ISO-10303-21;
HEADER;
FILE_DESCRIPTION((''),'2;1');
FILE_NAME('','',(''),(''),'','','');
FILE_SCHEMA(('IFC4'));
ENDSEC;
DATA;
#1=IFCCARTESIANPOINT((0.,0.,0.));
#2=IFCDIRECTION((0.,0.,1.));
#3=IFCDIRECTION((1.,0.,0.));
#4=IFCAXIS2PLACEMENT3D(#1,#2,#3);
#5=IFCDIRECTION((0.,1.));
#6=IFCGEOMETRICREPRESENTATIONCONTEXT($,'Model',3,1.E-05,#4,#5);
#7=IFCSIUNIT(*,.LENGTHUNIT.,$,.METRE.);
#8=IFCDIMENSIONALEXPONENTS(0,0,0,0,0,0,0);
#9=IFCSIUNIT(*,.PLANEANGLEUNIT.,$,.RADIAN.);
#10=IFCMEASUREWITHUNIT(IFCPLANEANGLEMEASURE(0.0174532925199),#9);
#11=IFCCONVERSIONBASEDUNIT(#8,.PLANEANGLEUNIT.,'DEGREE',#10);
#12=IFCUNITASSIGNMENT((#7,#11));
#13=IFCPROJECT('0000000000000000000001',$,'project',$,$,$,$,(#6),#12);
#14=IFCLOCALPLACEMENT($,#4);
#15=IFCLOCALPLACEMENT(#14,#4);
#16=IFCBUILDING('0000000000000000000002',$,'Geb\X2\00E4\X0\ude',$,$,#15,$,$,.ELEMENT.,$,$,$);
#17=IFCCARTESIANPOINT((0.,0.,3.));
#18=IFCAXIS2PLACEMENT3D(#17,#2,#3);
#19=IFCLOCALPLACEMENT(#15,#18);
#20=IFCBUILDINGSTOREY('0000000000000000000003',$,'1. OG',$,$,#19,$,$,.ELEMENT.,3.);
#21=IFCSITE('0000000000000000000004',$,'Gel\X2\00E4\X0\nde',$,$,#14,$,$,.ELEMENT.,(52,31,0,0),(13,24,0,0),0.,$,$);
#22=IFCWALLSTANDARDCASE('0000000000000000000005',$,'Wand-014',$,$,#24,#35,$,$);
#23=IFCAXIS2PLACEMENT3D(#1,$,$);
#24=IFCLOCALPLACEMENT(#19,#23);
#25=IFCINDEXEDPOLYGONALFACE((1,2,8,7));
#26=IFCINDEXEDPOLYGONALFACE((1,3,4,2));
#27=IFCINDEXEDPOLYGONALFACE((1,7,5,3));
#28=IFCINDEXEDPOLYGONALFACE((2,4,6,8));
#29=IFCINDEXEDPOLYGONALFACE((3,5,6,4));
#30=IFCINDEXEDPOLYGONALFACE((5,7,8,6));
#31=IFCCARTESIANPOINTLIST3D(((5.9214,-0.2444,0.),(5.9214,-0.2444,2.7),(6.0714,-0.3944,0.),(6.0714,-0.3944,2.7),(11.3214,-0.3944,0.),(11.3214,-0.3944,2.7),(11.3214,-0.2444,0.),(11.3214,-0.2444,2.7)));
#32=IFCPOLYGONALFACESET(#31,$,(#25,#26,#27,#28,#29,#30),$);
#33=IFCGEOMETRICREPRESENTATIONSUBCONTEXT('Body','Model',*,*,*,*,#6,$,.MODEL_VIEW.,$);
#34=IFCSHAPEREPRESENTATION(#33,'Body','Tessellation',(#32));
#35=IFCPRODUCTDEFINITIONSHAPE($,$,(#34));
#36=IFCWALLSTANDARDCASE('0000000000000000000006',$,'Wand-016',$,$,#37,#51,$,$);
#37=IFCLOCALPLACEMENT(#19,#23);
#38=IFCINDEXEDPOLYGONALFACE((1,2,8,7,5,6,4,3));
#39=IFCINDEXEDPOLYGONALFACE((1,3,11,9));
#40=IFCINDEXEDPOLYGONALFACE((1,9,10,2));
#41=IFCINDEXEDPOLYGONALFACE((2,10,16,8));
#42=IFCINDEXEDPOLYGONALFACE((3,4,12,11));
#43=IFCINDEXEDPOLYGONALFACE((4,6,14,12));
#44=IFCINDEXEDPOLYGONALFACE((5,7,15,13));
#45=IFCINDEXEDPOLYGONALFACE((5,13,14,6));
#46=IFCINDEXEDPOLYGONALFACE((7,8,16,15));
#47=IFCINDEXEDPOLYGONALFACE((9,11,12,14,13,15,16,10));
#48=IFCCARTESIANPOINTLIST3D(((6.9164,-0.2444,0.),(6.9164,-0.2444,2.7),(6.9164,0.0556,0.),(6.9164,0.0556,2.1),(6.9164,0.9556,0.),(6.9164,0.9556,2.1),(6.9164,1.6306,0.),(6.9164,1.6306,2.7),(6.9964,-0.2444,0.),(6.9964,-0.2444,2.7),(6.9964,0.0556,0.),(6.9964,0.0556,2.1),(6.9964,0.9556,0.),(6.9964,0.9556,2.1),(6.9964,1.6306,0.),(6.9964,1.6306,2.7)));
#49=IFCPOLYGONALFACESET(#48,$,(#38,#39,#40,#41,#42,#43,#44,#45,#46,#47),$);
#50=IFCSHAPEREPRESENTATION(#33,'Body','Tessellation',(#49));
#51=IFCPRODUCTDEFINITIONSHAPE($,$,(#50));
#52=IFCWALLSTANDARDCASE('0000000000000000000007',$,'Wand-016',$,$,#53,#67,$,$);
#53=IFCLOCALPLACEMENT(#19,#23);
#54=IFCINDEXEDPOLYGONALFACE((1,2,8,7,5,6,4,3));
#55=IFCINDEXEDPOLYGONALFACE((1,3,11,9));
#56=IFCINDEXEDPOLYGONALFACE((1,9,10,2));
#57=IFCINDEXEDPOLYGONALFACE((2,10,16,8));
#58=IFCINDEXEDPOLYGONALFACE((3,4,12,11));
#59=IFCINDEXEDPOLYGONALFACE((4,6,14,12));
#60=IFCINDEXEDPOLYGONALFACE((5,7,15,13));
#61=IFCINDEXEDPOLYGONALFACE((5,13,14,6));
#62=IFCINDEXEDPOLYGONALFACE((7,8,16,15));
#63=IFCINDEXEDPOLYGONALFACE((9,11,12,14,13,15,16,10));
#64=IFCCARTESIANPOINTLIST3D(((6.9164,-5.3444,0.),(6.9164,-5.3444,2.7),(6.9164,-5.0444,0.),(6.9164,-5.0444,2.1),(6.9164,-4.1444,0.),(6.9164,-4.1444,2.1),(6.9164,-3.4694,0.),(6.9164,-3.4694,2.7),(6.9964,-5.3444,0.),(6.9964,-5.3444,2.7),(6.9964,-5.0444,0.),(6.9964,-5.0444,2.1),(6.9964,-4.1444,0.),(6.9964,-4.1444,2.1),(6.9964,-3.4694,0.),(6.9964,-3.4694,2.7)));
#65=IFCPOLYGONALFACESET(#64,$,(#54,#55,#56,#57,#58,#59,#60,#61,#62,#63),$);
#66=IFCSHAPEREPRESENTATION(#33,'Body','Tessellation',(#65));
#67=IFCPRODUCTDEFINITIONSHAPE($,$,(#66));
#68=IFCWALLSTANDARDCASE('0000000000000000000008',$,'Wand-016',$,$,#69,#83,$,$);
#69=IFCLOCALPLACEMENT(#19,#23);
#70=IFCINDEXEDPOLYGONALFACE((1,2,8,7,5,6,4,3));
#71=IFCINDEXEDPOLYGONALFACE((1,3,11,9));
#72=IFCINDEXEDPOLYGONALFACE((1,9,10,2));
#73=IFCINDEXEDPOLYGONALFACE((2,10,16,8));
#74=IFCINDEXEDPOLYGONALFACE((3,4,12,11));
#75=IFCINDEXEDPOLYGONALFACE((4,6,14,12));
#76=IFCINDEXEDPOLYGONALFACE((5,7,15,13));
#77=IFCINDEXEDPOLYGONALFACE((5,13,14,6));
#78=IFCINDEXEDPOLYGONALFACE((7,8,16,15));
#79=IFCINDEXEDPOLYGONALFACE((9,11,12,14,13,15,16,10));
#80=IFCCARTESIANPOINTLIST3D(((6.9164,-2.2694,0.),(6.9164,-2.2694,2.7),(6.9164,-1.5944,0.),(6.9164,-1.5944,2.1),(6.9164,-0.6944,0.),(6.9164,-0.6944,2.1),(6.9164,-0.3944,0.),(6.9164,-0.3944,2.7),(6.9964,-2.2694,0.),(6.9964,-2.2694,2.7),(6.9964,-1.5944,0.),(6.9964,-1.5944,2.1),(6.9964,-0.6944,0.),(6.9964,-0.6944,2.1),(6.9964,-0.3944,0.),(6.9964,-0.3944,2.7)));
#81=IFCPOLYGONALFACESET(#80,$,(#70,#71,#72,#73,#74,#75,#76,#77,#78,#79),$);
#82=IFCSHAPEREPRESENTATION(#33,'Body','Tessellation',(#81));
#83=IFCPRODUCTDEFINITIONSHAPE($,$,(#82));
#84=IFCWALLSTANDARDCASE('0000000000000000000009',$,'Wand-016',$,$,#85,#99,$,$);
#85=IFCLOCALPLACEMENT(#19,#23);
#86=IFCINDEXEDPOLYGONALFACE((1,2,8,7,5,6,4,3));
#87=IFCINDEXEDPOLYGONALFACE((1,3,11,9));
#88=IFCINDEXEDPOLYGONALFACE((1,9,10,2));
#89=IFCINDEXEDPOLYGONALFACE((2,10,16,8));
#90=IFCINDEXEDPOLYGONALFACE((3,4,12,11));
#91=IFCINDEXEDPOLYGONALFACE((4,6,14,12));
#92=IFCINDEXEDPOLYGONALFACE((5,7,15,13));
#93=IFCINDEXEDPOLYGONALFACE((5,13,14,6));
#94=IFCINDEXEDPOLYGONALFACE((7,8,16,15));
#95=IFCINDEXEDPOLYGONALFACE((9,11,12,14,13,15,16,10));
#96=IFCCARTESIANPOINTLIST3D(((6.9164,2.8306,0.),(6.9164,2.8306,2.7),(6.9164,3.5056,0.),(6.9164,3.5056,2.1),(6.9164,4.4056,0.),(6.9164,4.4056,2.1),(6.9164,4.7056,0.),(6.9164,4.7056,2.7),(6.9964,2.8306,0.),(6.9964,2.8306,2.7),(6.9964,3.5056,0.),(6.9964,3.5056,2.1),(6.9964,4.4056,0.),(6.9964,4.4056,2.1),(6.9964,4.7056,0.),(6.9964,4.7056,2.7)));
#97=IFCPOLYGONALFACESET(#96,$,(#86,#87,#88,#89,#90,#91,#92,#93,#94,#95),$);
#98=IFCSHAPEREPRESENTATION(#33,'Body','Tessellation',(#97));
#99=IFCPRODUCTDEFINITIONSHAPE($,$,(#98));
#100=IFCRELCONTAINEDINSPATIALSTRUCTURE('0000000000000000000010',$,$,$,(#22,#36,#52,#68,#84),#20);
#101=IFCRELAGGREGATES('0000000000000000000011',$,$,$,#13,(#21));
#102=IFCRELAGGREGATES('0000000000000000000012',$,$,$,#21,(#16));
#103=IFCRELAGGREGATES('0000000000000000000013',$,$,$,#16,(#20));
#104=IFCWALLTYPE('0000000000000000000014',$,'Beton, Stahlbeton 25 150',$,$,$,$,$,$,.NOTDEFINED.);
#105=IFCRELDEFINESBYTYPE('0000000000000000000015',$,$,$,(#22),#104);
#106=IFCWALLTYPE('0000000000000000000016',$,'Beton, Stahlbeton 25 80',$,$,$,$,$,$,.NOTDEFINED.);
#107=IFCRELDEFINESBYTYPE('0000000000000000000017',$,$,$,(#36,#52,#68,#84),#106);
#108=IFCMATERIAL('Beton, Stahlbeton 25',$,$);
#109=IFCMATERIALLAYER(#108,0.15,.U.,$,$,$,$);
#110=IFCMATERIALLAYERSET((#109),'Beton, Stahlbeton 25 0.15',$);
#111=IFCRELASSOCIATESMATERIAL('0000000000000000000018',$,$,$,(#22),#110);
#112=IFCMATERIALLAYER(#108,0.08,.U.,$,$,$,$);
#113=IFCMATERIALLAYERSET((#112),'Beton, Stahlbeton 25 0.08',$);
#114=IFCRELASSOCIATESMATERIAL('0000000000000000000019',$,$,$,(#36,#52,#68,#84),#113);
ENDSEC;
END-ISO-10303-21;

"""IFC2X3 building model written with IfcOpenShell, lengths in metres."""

from ifc_helpers import new_model, entity, si_unit, converted_unit, direction, frame, origin_with_axes, origin_2d_with_axis, place, context, subcontext, project, spatial, polyline, rectangle, outline, extrude, material, layer, layer_set, layer_usage, type_object, element, save


model = new_model("IFC2X3")

# Units and contexts
model_context = context("Model", 3, precision=1e-05, world=origin_with_axes(), true_north=direction((0.0, 1.0)))
body_context = subcontext(model_context, "Body", "Model", "MODEL_VIEW")
ifc_project = project(units=[si_unit("LENGTHUNIT", "METRE"), converted_unit("PLANEANGLEUNIT", "DEGREE", entity("IfcPlaneAngleMeasure", 0.0174532925199), si_unit("PLANEANGLEUNIT", "RADIAN"), dimensions=[0, 0, 0, 0, 0, 0, 0])], contexts=[model_context])

# Site, building, storey
site_placement = place(None, origin_with_axes())
site = spatial("IfcSite", under=ifc_project, at=site_placement, Name="Gelände", CompositionType="ELEMENT", RefLatitude=(52, 31, 0, 0), RefLongitude=(13, 24, 0, 0), RefElevation=0.0)
building_placement = place(site_placement, origin_with_axes())
building = spatial("IfcBuilding", under=site, at=building_placement, Name="Gebäude", CompositionType="ELEMENT")
storey_placement = place(building_placement, frame((0.0, 0.0, 3.0), z_axis=(0.0, 0.0, 1.0), x_axis=(1.0, 0.0, 0.0)))
storey = spatial("IfcBuildingStorey", under=building, at=storey_placement, Name="1. OG", CompositionType="ELEMENT", Elevation=3.0)

# Shared definitions
ifc_material = material(Name="Beton, Stahlbeton 25")
ifc_layer_1 = layer(ifc_material, 0.15, ventilated="UNKNOWN")
ifc_layer_set_1 = layer_set([ifc_layer_1], Name="Beton, Stahlbeton 25 0.15")
wall_type_1 = type_object("IfcWallType", Name="Beton, Stahlbeton 25 150", PredefinedType="NOTDEFINED")

# Wall
ifc_layer_usage_1 = layer_usage(ifc_layer_set_1, "AXIS2", "NEGATIVE", 0.075)
wall_1_placement = place(storey_placement, frame((11.3214, -0.3194, 0.0), z_axis=(0.0, 0.0, 1.0), x_axis=(-1.0, 0.0, 0.0)))
element("IfcWallStandardCase", 1, at=wall_1_placement, inside=storey, type_object=wall_type_1, material=ifc_layer_usage_1, Name="Wand-014", context=body_context, shape_type="SweptSolid", body=[
    extrude(outline(polyline([(0.0, -0.075), (5.4, -0.075), (5.25, 0.075), (0.0, 0.075), (0.0, -0.075)])), origin_with_axes(), (0.0, 0.0, 1.0), 2.7),
])

# Walls, openings
ifc_layer_2 = layer(ifc_material, 0.08, ventilated="UNKNOWN")
ifc_layer_set_2 = layer_set([ifc_layer_2], Name="Beton, Stahlbeton 25 0.08")
ifc_layer_usage_2 = layer_usage(ifc_layer_set_2, "AXIS2", "POSITIVE", 0.0)
wall_type_2 = type_object("IfcWallType", Name="Beton, Stahlbeton 25 80", PredefinedType="NOTDEFINED")
wall_2_placement = place(storey_placement, frame((6.9164, 1.6306, 0.0), z_axis=(0.0, 0.0, 1.0), x_axis=(0.0, -1.0, 0.0)))
wall_2 = element("IfcWallStandardCase", 2, at=wall_2_placement, inside=storey, type_object=wall_type_2, material=ifc_layer_usage_2, Name="Wand-016", context=body_context, shape_type="SweptSolid", body=[
    extrude(outline(polyline([(0.0, 0.0), (1.875, 0.0), (1.875, 0.08), (0.0, 0.08), (0.0, 0.0)])), origin_with_axes(), (0.0, 0.0, 1.0), 2.7),
])
opening_1_placement = place(wall_2_placement, frame((1.125, 0.0, 0.0), z_axis=(0.0, 0.0, 1.0), x_axis=(1.0, 0.0, 0.0)))
element("IfcOpeningElement", 3, at=opening_1_placement, cuts=wall_2, context=body_context, shape_type="SweptSolid", body=[
    extrude(rectangle(XDim=0.9, YDim=2.1, at=origin_2d_with_axis()), frame((0.0, -0.08, 1.05), z_axis=(0.0, 1.0, 0.0), x_axis=(1.0, 0.0, 0.0)), (0.0, 0.0, 1.0), 0.08),
    extrude(rectangle(XDim=0.9, YDim=2.1, at=origin_2d_with_axis()), frame((0.0, 0.08, 1.05), z_axis=(0.0, -1.0, 0.0), x_axis=(1.0, 0.0, 0.0)), (0.0, 0.0, 1.0), 0.08),
])
ifc_layer_usage_3 = layer_usage(ifc_layer_set_2, "AXIS2", "POSITIVE", 0.0)
wall_3_placement = place(storey_placement, frame((6.9164, -3.4694, 0.0), z_axis=(0.0, 0.0, 1.0), x_axis=(0.0, -1.0, 0.0)))
wall_3 = element("IfcWallStandardCase", 4, at=wall_3_placement, inside=storey, type_object=wall_type_2, material=ifc_layer_usage_3, Name="Wand-016", context=body_context, shape_type="SweptSolid", body=[
    extrude(outline(polyline([(0.0, 0.0), (1.875, 0.0), (1.875, 0.08), (0.0, 0.08), (0.0, 0.0)])), origin_with_axes(), (0.0, 0.0, 1.0), 2.7),
])
opening_2_placement = place(wall_3_placement, frame((1.125, 0.0, 0.0), z_axis=(0.0, 0.0, 1.0), x_axis=(1.0, 0.0, 0.0)))
element("IfcOpeningElement", 5, at=opening_2_placement, cuts=wall_3, context=body_context, shape_type="SweptSolid", body=[
    extrude(rectangle(XDim=0.9, YDim=2.1, at=origin_2d_with_axis()), frame((0.0, -0.08, 1.05), z_axis=(0.0, 1.0, 0.0), x_axis=(1.0, 0.0, 0.0)), (0.0, 0.0, 1.0), 0.08),
    extrude(rectangle(XDim=0.9, YDim=2.1, at=origin_2d_with_axis()), frame((0.0, 0.08, 1.05), z_axis=(0.0, -1.0, 0.0), x_axis=(1.0, 0.0, 0.0)), (0.0, 0.0, 1.0), 0.08),
])
ifc_layer_usage_4 = layer_usage(ifc_layer_set_2, "AXIS2", "NEGATIVE", 0.0)
wall_4_placement = place(storey_placement, frame((6.9164, -2.2694, 0.0), z_axis=(0.0, 0.0, 1.0), x_axis=(0.0, 1.0, 0.0)))
wall_4 = element("IfcWallStandardCase", 6, at=wall_4_placement, inside=storey, type_object=wall_type_2, material=ifc_layer_usage_4, Name="Wand-016", context=body_context, shape_type="SweptSolid", body=[
    extrude(outline(polyline([(0.0, -0.08), (1.875, -0.08), (1.875, 0.0), (0.0, 0.0), (0.0, -0.08)])), origin_with_axes(), (0.0, 0.0, 1.0), 2.7),
])
opening_3_placement = place(wall_4_placement, frame((1.125, 0.0, 0.0), z_axis=(0.0, 0.0, 1.0), x_axis=(1.0, 0.0, 0.0)))
element("IfcOpeningElement", 7, at=opening_3_placement, cuts=wall_4, context=body_context, shape_type="SweptSolid", body=[
    extrude(rectangle(XDim=0.9, YDim=2.1, at=origin_2d_with_axis()), frame((0.0, 0.08, 1.05), z_axis=(0.0, -1.0, 0.0), x_axis=(1.0, 0.0, 0.0)), (0.0, 0.0, 1.0), 0.08),
    extrude(rectangle(XDim=0.9, YDim=2.1, at=origin_2d_with_axis()), frame((0.0, -0.08, 1.05), z_axis=(0.0, 1.0, 0.0), x_axis=(1.0, 0.0, 0.0)), (0.0, 0.0, 1.0), 0.08),
])
ifc_layer_usage_5 = layer_usage(ifc_layer_set_2, "AXIS2", "NEGATIVE", 0.0)
wall_5_placement = place(storey_placement, frame((6.9164, 2.8306, 0.0), z_axis=(0.0, 0.0, 1.0), x_axis=(0.0, 1.0, 0.0)))
wall_5 = element("IfcWallStandardCase", 8, at=wall_5_placement, inside=storey, type_object=wall_type_2, material=ifc_layer_usage_5, Name="Wand-016", context=body_context, shape_type="SweptSolid", body=[
    extrude(outline(polyline([(0.0, -0.08), (1.875, -0.08), (1.875, 0.0), (0.0, 0.0), (0.0, -0.08)])), origin_with_axes(), (0.0, 0.0, 1.0), 2.7),
])
opening_4_placement = place(wall_5_placement, frame((1.125, 0.0, 0.0), z_axis=(0.0, 0.0, 1.0), x_axis=(1.0, 0.0, 0.0)))
element("IfcOpeningElement", 9, at=opening_4_placement, cuts=wall_5, context=body_context, shape_type="SweptSolid", body=[
    extrude(rectangle(XDim=0.9, YDim=2.1, at=origin_2d_with_axis()), frame((0.0, 0.08, 1.05), z_axis=(0.0, -1.0, 0.0), x_axis=(1.0, 0.0, 0.0)), (0.0, 0.0, 1.0), 0.08),
    extrude(rectangle(XDim=0.9, YDim=2.1, at=origin_2d_with_axis()), frame((0.0, -0.08, 1.05), z_axis=(0.0, 1.0, 0.0), x_axis=(1.0, 0.0, 0.0)), (0.0, 0.0, 1.0), 0.08),
])

save(model, "model.ifc")
